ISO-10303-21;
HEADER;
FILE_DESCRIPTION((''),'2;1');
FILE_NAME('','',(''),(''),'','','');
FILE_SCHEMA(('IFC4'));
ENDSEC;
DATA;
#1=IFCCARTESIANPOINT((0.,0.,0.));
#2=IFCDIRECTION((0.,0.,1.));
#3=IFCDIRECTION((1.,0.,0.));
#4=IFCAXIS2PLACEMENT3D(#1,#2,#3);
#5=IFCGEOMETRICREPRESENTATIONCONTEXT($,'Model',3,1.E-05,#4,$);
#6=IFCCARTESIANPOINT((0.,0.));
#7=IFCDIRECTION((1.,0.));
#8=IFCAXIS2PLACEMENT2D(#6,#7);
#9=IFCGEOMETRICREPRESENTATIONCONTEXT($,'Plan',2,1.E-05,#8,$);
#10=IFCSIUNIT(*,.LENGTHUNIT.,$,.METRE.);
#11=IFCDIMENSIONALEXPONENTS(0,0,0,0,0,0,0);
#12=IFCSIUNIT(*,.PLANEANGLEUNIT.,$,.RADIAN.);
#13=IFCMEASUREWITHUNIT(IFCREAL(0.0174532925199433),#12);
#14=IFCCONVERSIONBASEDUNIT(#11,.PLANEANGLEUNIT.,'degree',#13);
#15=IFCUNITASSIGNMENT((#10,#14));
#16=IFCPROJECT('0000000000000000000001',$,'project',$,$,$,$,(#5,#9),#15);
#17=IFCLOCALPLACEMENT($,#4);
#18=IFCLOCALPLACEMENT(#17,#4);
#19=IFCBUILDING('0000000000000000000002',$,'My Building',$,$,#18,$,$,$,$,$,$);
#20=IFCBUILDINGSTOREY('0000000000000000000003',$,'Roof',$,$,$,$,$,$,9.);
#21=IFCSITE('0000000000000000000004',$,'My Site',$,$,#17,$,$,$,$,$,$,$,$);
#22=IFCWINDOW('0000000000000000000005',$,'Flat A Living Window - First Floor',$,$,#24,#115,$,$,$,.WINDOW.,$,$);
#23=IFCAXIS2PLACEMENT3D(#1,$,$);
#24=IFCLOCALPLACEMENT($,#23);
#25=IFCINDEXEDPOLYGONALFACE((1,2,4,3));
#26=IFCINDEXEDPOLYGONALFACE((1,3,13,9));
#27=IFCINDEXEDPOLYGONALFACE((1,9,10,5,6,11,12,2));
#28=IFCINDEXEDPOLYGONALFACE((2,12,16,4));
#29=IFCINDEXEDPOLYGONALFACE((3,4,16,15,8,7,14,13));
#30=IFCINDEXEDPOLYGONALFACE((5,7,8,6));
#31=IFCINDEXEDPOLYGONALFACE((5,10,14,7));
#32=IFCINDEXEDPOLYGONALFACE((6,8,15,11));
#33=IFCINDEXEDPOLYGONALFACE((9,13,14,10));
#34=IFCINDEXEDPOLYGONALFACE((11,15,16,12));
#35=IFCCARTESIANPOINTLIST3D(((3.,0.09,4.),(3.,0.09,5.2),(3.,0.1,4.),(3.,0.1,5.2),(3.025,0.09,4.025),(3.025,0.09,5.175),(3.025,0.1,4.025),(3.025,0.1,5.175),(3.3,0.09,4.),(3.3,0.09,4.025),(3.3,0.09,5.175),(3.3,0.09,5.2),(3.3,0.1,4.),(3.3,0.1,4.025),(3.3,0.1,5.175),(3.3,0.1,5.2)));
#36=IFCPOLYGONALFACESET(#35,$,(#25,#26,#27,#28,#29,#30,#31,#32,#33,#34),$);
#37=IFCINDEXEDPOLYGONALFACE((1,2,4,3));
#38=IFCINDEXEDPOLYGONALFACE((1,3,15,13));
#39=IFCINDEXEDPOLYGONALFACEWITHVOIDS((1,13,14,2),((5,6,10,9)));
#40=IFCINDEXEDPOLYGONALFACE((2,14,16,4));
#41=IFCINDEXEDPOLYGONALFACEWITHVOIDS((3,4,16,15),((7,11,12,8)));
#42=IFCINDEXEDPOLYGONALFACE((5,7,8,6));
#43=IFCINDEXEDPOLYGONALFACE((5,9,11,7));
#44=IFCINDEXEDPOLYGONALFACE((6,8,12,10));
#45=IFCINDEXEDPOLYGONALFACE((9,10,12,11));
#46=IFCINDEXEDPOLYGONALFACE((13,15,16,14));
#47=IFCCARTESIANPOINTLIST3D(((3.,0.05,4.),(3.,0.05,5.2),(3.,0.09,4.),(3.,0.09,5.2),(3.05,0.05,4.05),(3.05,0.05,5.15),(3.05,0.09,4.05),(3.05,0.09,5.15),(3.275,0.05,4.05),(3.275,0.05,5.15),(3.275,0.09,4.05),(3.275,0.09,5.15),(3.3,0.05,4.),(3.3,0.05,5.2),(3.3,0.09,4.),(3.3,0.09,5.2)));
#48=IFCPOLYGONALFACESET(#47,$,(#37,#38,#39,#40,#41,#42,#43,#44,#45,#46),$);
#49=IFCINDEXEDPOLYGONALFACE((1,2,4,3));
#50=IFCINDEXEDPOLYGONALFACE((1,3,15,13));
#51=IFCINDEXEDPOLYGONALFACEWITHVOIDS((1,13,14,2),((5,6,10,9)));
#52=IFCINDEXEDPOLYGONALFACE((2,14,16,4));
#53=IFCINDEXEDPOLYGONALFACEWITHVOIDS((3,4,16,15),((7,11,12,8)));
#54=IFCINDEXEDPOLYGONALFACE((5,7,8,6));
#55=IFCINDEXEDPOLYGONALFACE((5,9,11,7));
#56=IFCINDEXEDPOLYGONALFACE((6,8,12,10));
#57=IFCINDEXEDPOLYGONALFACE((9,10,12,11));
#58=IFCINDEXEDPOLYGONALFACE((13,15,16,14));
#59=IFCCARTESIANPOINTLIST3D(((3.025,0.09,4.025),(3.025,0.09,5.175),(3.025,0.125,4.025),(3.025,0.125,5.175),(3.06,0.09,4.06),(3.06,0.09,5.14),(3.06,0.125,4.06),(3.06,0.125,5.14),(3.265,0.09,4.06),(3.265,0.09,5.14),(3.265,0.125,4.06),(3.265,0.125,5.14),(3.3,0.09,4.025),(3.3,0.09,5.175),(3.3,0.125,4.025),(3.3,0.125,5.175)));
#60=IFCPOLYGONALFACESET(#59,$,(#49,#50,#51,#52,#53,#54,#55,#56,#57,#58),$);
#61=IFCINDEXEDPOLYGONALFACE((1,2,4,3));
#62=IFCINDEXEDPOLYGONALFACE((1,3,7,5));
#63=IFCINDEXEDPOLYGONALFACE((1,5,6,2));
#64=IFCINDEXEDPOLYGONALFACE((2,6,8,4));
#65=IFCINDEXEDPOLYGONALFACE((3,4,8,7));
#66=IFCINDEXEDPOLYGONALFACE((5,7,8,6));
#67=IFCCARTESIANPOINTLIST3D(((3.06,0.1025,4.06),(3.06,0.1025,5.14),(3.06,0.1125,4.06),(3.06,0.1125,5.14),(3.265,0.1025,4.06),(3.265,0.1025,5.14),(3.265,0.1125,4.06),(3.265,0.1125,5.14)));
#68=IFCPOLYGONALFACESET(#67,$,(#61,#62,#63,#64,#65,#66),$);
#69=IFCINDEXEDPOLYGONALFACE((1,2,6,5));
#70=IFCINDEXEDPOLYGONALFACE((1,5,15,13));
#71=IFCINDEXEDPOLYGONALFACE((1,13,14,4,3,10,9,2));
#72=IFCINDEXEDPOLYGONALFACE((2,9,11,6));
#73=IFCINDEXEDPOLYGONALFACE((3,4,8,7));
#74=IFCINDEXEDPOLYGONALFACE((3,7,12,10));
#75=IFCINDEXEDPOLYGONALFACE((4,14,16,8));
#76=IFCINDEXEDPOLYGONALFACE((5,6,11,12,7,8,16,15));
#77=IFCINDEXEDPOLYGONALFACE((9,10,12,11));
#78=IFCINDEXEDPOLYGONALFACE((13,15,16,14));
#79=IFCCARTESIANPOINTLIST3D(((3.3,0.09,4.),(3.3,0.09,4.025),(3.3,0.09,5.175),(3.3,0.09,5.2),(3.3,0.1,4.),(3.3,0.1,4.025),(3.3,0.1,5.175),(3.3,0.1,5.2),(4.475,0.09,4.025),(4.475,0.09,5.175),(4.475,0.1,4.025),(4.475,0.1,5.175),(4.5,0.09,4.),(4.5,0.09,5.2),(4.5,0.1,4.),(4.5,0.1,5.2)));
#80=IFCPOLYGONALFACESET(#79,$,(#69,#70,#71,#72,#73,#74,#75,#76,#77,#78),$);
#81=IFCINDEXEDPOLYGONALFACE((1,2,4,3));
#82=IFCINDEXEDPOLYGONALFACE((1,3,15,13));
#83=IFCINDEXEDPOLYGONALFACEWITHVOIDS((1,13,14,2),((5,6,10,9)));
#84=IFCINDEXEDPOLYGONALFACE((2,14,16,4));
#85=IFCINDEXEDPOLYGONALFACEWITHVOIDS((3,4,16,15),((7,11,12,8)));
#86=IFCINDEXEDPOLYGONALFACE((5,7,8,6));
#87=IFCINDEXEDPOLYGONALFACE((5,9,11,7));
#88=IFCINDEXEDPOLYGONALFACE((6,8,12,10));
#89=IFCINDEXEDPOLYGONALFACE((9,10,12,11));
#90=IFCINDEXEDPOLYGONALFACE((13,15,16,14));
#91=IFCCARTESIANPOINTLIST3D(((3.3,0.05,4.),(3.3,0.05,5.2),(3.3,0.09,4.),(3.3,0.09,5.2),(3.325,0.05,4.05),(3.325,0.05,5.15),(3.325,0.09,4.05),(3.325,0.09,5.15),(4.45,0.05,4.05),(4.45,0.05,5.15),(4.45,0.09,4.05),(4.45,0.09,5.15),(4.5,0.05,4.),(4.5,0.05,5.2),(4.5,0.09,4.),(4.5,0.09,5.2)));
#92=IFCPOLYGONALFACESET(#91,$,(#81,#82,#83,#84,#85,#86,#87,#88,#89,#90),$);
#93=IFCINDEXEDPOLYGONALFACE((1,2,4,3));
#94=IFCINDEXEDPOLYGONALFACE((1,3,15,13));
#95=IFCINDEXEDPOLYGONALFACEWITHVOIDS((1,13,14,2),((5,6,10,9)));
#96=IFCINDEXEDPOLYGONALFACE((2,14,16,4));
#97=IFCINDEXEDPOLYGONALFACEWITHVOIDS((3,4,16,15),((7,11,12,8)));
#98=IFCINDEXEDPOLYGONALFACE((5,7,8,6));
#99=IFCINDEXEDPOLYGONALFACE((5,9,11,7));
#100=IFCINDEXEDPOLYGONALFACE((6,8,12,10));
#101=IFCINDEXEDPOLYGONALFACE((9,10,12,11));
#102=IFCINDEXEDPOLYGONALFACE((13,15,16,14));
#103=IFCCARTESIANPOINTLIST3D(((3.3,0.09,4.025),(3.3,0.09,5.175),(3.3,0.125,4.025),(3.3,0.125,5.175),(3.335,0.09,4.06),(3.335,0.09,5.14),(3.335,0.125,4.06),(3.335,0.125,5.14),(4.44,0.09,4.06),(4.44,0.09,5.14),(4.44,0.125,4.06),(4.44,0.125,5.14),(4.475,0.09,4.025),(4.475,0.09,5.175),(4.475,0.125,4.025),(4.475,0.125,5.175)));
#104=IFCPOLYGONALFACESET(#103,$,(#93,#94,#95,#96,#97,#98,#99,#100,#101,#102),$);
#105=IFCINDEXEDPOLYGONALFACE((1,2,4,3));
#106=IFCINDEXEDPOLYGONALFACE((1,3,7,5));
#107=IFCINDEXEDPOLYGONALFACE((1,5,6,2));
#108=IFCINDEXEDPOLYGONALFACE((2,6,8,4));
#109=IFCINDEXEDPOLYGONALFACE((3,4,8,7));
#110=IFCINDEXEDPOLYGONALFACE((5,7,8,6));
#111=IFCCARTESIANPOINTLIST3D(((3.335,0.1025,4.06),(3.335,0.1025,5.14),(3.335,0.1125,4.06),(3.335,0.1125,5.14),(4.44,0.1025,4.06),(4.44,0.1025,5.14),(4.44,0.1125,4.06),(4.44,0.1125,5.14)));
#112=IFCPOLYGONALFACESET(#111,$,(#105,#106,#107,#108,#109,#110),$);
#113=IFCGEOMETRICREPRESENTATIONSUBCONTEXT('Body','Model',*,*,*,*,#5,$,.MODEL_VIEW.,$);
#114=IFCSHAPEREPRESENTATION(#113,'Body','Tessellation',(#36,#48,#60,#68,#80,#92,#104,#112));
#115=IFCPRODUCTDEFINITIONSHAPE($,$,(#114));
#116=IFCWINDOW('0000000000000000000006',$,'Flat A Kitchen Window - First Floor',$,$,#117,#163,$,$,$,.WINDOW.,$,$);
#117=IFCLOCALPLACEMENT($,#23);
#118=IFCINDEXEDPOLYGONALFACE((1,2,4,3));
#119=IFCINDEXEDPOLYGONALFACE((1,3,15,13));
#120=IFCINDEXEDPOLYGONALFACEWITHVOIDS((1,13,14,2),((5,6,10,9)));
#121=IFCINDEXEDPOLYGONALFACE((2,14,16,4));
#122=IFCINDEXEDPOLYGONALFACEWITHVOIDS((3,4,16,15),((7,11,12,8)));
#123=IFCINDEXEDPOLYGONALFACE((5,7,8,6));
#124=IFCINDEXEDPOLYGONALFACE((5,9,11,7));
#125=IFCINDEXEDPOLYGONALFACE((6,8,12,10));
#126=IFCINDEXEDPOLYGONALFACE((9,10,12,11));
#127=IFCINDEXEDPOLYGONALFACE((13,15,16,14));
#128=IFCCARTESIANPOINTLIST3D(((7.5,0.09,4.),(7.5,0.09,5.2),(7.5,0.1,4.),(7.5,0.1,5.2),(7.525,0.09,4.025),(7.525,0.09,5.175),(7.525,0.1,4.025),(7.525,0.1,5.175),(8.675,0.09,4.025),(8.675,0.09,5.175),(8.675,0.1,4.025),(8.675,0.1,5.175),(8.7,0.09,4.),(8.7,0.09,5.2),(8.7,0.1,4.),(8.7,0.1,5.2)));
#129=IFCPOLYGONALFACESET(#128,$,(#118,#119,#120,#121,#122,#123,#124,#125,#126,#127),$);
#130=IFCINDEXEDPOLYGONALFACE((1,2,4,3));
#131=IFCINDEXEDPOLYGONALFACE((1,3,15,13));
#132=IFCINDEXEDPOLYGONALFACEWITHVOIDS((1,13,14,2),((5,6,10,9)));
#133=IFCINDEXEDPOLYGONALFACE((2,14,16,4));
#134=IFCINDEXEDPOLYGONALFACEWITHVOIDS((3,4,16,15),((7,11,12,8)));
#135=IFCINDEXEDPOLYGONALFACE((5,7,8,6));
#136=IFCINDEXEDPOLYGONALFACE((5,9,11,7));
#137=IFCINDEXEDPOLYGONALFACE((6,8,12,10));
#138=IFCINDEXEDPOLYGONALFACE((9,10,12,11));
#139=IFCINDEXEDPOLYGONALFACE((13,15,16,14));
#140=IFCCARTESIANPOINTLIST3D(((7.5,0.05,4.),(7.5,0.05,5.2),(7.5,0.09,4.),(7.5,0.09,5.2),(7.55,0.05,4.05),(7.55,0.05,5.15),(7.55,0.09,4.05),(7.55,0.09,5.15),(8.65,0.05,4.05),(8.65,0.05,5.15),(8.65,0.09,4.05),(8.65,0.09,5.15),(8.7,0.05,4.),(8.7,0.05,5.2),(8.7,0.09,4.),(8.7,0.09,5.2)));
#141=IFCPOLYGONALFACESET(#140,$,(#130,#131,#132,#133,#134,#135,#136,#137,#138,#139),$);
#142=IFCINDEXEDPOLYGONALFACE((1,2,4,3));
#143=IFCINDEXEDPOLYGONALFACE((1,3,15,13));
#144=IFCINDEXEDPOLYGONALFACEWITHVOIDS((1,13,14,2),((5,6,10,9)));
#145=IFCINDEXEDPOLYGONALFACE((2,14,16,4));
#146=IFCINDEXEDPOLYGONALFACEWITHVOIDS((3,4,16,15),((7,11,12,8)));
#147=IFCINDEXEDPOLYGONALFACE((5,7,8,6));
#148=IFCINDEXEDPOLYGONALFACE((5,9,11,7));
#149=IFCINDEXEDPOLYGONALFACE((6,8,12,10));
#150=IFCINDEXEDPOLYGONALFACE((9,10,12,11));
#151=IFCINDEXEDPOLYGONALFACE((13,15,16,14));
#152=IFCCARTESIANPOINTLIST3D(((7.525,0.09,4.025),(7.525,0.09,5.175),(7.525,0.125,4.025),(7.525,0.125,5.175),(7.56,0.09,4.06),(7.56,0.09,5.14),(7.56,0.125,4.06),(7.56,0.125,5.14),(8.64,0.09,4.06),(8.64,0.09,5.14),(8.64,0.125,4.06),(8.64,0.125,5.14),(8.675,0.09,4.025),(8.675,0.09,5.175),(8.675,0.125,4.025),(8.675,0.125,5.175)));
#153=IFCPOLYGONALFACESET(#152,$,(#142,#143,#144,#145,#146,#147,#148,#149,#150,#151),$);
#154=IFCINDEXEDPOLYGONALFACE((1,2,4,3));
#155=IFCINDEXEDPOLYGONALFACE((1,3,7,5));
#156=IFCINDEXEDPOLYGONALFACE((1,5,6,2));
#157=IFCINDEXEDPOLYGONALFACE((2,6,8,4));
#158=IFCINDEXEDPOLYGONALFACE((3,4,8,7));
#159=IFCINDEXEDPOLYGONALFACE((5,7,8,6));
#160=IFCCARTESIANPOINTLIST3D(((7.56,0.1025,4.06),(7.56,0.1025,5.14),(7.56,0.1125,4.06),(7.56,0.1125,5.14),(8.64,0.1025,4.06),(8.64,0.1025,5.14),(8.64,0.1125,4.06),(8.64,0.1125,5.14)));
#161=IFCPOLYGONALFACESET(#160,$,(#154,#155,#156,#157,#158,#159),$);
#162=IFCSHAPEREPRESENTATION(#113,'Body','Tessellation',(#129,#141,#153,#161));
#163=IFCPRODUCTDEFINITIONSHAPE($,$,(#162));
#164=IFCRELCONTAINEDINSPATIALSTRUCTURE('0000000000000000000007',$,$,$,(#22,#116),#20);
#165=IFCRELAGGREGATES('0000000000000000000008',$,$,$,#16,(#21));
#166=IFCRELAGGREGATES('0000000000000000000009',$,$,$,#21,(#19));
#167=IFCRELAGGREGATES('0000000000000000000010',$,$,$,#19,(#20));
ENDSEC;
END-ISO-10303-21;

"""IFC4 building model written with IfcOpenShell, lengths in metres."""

from ifc_helpers import new_model, entity, si_unit, converted_unit, frame, origin_with_axes, origin_2d_with_axis, place, context, subcontext, project, spatial, line, indexed_curve, outline, extrude, element, save


model = new_model("IFC4")

# Units and contexts
model_context = context("Model", 3, precision=1e-05, world=origin_with_axes())
plan_context = context("Plan", 2, precision=1e-05, world=origin_2d_with_axis())
body_context = subcontext(model_context, "Body", "Model", "MODEL_VIEW")
ifc_project = project(units=[si_unit("LENGTHUNIT", "METRE"), converted_unit("PLANEANGLEUNIT", "degree", entity("IfcReal", 0.0174532925199433), si_unit("PLANEANGLEUNIT", "RADIAN"), dimensions=[0, 0, 0, 0, 0, 0, 0])], contexts=[model_context, plan_context])

# Site, building, storey
site_placement = place(None, origin_with_axes())
site = spatial("IfcSite", under=ifc_project, at=site_placement, Name="My Site")
building_placement = place(site_placement, origin_with_axes())
building = spatial("IfcBuilding", under=site, at=building_placement, Name="My Building")
storey = spatial("IfcBuildingStorey", under=building, Name="Roof", Elevation=9.0)

# Windows
window_1_placement = place(None, frame((3.0, 0.0, 4.0), z_axis=(0.0, 0.0, 1.0), x_axis=(1.0, 0.0, 0.0)))
element("IfcWindow", 1, at=window_1_placement, inside=storey, Name="Flat A Living Window - First Floor", PredefinedType="WINDOW", context=body_context, shape_type="SweptSolid", body=[
    extrude(outline(indexed_curve([(0.3, 0.0), (0.0, 0.0), (0.0, 1.2), (0.3, 1.2), (0.3, 1.175), (0.025, 1.175), (0.025, 0.025), (0.3, 0.025)], segments=[line(1, 2, 3, 4, 5, 6, 7, 8, 1)])), frame((0.0, 0.09, 0.0), z_axis=(0.0, -1.0, 0.0), x_axis=(1.0, 0.0, 0.0)), (0.0, 0.0, -1.0), 0.01),
    extrude(outline(indexed_curve([(0.0, 0.0), (0.3, 0.0), (0.3, 1.2), (0.0, 1.2)], segments=[line(1, 2, 3, 4, 1)]), holes=[indexed_curve([(0.05, 0.05), (0.275, 0.05), (0.275, 1.15), (0.05, 1.15)], segments=[line(1, 2, 3, 4, 1)])]), frame((0.0, 0.05, 0.0), z_axis=(0.0, -1.0, 0.0), x_axis=(1.0, 0.0, 0.0)), (0.0, 0.0, -1.0), 0.04),
    extrude(outline(indexed_curve([(0.0, 0.0), (0.275, 0.0), (0.275, 1.15), (0.0, 1.15)], segments=[line(1, 2, 3, 4, 1)]), holes=[indexed_curve([(0.035, 0.035), (0.24, 0.035), (0.24, 1.115), (0.035, 1.115)], segments=[line(1, 2, 3, 4, 1)])]), frame((0.025, 0.09, 0.025), z_axis=(0.0, -1.0, 0.0), x_axis=(1.0, 0.0, 0.0)), (0.0, 0.0, -1.0), 0.035),
    extrude(outline(indexed_curve([(0.035, 0.035), (0.24, 0.035), (0.24, 1.115), (0.035, 1.115)], segments=[line(1, 2, 3, 4, 1)])), frame((0.025, 0.1025, 0.025), z_axis=(0.0, -1.0, 0.0), x_axis=(1.0, 0.0, 0.0)), (0.0, 0.0, -1.0), 0.01),
    extrude(outline(indexed_curve([(0.0, 1.2), (1.2, 1.2), (1.2, 0.0), (0.0, 0.0), (0.0, 0.025), (1.175, 0.025), (1.175, 1.175), (0.0, 1.175)], segments=[line(1, 2, 3, 4, 5, 6, 7, 8, 1)])), frame((0.3, 0.09, 0.0), z_axis=(0.0, -1.0, 0.0), x_axis=(1.0, 0.0, 0.0)), (0.0, 0.0, -1.0), 0.01),
    extrude(outline(indexed_curve([(0.0, 0.0), (1.2, 0.0), (1.2, 1.2), (0.0, 1.2)], segments=[line(1, 2, 3, 4, 1)]), holes=[indexed_curve([(0.025, 0.05), (1.15, 0.05), (1.15, 1.15), (0.025, 1.15)], segments=[line(1, 2, 3, 4, 1)])]), frame((0.3, 0.05, 0.0), z_axis=(0.0, -1.0, 0.0), x_axis=(1.0, 0.0, 0.0)), (0.0, 0.0, -1.0), 0.04),
    extrude(outline(indexed_curve([(0.0, 0.0), (1.175, 0.0), (1.175, 1.15), (0.0, 1.15)], segments=[line(1, 2, 3, 4, 1)]), holes=[indexed_curve([(0.035, 0.035), (1.14, 0.035), (1.14, 1.115), (0.035, 1.115)], segments=[line(1, 2, 3, 4, 1)])]), frame((0.3, 0.09, 0.025), z_axis=(0.0, -1.0, 0.0), x_axis=(1.0, 0.0, 0.0)), (0.0, 0.0, -1.0), 0.035),
    extrude(outline(indexed_curve([(0.035, 0.035), (1.14, 0.035), (1.14, 1.115), (0.035, 1.115)], segments=[line(1, 2, 3, 4, 1)])), frame((0.3, 0.1025, 0.025), z_axis=(0.0, -1.0, 0.0), x_axis=(1.0, 0.0, 0.0)), (0.0, 0.0, -1.0), 0.01),
])
window_2_placement = place(None, frame((7.5, 0.0, 4.0), z_axis=(0.0, 0.0, 1.0), x_axis=(1.0, 0.0, 0.0)))
element("IfcWindow", 2, at=window_2_placement, inside=storey, Name="Flat A Kitchen Window - First Floor", PredefinedType="WINDOW", context=body_context, shape_type="SweptSolid", body=[
    extrude(outline(indexed_curve([(0.0, 0.0), (1.2, 0.0), (1.2, 1.2), (0.0, 1.2)], segments=[line(1, 2, 3, 4, 1)]), holes=[indexed_curve([(0.025, 0.025), (1.175, 0.025), (1.175, 1.175), (0.025, 1.175)], segments=[line(1, 2, 3, 4, 1)])]), frame((0.0, 0.09, 0.0), z_axis=(0.0, -1.0, 0.0), x_axis=(1.0, 0.0, 0.0)), (0.0, 0.0, -1.0), 0.01),
    extrude(outline(indexed_curve([(0.0, 0.0), (1.2, 0.0), (1.2, 1.2), (0.0, 1.2)], segments=[line(1, 2, 3, 4, 1)]), holes=[indexed_curve([(0.05, 0.05), (1.15, 0.05), (1.15, 1.15), (0.05, 1.15)], segments=[line(1, 2, 3, 4, 1)])]), frame((0.0, 0.05, 0.0), z_axis=(0.0, -1.0, 0.0), x_axis=(1.0, 0.0, 0.0)), (0.0, 0.0, -1.0), 0.04),
    extrude(outline(indexed_curve([(0.0, 0.0), (1.15, 0.0), (1.15, 1.15), (0.0, 1.15)], segments=[line(1, 2, 3, 4, 1)]), holes=[indexed_curve([(0.035, 0.035), (1.115, 0.035), (1.115, 1.115), (0.035, 1.115)], segments=[line(1, 2, 3, 4, 1)])]), frame((0.025, 0.09, 0.025), z_axis=(0.0, -1.0, 0.0), x_axis=(1.0, 0.0, 0.0)), (0.0, 0.0, -1.0), 0.035),
    extrude(outline(indexed_curve([(0.035, 0.035), (1.115, 0.035), (1.115, 1.115), (0.035, 1.115)], segments=[line(1, 2, 3, 4, 1)])), frame((0.025, 0.1025, 0.025), z_axis=(0.0, -1.0, 0.0), x_axis=(1.0, 0.0, 0.0)), (0.0, 0.0, -1.0), 0.01),
])

save(model, "model.ifc")
